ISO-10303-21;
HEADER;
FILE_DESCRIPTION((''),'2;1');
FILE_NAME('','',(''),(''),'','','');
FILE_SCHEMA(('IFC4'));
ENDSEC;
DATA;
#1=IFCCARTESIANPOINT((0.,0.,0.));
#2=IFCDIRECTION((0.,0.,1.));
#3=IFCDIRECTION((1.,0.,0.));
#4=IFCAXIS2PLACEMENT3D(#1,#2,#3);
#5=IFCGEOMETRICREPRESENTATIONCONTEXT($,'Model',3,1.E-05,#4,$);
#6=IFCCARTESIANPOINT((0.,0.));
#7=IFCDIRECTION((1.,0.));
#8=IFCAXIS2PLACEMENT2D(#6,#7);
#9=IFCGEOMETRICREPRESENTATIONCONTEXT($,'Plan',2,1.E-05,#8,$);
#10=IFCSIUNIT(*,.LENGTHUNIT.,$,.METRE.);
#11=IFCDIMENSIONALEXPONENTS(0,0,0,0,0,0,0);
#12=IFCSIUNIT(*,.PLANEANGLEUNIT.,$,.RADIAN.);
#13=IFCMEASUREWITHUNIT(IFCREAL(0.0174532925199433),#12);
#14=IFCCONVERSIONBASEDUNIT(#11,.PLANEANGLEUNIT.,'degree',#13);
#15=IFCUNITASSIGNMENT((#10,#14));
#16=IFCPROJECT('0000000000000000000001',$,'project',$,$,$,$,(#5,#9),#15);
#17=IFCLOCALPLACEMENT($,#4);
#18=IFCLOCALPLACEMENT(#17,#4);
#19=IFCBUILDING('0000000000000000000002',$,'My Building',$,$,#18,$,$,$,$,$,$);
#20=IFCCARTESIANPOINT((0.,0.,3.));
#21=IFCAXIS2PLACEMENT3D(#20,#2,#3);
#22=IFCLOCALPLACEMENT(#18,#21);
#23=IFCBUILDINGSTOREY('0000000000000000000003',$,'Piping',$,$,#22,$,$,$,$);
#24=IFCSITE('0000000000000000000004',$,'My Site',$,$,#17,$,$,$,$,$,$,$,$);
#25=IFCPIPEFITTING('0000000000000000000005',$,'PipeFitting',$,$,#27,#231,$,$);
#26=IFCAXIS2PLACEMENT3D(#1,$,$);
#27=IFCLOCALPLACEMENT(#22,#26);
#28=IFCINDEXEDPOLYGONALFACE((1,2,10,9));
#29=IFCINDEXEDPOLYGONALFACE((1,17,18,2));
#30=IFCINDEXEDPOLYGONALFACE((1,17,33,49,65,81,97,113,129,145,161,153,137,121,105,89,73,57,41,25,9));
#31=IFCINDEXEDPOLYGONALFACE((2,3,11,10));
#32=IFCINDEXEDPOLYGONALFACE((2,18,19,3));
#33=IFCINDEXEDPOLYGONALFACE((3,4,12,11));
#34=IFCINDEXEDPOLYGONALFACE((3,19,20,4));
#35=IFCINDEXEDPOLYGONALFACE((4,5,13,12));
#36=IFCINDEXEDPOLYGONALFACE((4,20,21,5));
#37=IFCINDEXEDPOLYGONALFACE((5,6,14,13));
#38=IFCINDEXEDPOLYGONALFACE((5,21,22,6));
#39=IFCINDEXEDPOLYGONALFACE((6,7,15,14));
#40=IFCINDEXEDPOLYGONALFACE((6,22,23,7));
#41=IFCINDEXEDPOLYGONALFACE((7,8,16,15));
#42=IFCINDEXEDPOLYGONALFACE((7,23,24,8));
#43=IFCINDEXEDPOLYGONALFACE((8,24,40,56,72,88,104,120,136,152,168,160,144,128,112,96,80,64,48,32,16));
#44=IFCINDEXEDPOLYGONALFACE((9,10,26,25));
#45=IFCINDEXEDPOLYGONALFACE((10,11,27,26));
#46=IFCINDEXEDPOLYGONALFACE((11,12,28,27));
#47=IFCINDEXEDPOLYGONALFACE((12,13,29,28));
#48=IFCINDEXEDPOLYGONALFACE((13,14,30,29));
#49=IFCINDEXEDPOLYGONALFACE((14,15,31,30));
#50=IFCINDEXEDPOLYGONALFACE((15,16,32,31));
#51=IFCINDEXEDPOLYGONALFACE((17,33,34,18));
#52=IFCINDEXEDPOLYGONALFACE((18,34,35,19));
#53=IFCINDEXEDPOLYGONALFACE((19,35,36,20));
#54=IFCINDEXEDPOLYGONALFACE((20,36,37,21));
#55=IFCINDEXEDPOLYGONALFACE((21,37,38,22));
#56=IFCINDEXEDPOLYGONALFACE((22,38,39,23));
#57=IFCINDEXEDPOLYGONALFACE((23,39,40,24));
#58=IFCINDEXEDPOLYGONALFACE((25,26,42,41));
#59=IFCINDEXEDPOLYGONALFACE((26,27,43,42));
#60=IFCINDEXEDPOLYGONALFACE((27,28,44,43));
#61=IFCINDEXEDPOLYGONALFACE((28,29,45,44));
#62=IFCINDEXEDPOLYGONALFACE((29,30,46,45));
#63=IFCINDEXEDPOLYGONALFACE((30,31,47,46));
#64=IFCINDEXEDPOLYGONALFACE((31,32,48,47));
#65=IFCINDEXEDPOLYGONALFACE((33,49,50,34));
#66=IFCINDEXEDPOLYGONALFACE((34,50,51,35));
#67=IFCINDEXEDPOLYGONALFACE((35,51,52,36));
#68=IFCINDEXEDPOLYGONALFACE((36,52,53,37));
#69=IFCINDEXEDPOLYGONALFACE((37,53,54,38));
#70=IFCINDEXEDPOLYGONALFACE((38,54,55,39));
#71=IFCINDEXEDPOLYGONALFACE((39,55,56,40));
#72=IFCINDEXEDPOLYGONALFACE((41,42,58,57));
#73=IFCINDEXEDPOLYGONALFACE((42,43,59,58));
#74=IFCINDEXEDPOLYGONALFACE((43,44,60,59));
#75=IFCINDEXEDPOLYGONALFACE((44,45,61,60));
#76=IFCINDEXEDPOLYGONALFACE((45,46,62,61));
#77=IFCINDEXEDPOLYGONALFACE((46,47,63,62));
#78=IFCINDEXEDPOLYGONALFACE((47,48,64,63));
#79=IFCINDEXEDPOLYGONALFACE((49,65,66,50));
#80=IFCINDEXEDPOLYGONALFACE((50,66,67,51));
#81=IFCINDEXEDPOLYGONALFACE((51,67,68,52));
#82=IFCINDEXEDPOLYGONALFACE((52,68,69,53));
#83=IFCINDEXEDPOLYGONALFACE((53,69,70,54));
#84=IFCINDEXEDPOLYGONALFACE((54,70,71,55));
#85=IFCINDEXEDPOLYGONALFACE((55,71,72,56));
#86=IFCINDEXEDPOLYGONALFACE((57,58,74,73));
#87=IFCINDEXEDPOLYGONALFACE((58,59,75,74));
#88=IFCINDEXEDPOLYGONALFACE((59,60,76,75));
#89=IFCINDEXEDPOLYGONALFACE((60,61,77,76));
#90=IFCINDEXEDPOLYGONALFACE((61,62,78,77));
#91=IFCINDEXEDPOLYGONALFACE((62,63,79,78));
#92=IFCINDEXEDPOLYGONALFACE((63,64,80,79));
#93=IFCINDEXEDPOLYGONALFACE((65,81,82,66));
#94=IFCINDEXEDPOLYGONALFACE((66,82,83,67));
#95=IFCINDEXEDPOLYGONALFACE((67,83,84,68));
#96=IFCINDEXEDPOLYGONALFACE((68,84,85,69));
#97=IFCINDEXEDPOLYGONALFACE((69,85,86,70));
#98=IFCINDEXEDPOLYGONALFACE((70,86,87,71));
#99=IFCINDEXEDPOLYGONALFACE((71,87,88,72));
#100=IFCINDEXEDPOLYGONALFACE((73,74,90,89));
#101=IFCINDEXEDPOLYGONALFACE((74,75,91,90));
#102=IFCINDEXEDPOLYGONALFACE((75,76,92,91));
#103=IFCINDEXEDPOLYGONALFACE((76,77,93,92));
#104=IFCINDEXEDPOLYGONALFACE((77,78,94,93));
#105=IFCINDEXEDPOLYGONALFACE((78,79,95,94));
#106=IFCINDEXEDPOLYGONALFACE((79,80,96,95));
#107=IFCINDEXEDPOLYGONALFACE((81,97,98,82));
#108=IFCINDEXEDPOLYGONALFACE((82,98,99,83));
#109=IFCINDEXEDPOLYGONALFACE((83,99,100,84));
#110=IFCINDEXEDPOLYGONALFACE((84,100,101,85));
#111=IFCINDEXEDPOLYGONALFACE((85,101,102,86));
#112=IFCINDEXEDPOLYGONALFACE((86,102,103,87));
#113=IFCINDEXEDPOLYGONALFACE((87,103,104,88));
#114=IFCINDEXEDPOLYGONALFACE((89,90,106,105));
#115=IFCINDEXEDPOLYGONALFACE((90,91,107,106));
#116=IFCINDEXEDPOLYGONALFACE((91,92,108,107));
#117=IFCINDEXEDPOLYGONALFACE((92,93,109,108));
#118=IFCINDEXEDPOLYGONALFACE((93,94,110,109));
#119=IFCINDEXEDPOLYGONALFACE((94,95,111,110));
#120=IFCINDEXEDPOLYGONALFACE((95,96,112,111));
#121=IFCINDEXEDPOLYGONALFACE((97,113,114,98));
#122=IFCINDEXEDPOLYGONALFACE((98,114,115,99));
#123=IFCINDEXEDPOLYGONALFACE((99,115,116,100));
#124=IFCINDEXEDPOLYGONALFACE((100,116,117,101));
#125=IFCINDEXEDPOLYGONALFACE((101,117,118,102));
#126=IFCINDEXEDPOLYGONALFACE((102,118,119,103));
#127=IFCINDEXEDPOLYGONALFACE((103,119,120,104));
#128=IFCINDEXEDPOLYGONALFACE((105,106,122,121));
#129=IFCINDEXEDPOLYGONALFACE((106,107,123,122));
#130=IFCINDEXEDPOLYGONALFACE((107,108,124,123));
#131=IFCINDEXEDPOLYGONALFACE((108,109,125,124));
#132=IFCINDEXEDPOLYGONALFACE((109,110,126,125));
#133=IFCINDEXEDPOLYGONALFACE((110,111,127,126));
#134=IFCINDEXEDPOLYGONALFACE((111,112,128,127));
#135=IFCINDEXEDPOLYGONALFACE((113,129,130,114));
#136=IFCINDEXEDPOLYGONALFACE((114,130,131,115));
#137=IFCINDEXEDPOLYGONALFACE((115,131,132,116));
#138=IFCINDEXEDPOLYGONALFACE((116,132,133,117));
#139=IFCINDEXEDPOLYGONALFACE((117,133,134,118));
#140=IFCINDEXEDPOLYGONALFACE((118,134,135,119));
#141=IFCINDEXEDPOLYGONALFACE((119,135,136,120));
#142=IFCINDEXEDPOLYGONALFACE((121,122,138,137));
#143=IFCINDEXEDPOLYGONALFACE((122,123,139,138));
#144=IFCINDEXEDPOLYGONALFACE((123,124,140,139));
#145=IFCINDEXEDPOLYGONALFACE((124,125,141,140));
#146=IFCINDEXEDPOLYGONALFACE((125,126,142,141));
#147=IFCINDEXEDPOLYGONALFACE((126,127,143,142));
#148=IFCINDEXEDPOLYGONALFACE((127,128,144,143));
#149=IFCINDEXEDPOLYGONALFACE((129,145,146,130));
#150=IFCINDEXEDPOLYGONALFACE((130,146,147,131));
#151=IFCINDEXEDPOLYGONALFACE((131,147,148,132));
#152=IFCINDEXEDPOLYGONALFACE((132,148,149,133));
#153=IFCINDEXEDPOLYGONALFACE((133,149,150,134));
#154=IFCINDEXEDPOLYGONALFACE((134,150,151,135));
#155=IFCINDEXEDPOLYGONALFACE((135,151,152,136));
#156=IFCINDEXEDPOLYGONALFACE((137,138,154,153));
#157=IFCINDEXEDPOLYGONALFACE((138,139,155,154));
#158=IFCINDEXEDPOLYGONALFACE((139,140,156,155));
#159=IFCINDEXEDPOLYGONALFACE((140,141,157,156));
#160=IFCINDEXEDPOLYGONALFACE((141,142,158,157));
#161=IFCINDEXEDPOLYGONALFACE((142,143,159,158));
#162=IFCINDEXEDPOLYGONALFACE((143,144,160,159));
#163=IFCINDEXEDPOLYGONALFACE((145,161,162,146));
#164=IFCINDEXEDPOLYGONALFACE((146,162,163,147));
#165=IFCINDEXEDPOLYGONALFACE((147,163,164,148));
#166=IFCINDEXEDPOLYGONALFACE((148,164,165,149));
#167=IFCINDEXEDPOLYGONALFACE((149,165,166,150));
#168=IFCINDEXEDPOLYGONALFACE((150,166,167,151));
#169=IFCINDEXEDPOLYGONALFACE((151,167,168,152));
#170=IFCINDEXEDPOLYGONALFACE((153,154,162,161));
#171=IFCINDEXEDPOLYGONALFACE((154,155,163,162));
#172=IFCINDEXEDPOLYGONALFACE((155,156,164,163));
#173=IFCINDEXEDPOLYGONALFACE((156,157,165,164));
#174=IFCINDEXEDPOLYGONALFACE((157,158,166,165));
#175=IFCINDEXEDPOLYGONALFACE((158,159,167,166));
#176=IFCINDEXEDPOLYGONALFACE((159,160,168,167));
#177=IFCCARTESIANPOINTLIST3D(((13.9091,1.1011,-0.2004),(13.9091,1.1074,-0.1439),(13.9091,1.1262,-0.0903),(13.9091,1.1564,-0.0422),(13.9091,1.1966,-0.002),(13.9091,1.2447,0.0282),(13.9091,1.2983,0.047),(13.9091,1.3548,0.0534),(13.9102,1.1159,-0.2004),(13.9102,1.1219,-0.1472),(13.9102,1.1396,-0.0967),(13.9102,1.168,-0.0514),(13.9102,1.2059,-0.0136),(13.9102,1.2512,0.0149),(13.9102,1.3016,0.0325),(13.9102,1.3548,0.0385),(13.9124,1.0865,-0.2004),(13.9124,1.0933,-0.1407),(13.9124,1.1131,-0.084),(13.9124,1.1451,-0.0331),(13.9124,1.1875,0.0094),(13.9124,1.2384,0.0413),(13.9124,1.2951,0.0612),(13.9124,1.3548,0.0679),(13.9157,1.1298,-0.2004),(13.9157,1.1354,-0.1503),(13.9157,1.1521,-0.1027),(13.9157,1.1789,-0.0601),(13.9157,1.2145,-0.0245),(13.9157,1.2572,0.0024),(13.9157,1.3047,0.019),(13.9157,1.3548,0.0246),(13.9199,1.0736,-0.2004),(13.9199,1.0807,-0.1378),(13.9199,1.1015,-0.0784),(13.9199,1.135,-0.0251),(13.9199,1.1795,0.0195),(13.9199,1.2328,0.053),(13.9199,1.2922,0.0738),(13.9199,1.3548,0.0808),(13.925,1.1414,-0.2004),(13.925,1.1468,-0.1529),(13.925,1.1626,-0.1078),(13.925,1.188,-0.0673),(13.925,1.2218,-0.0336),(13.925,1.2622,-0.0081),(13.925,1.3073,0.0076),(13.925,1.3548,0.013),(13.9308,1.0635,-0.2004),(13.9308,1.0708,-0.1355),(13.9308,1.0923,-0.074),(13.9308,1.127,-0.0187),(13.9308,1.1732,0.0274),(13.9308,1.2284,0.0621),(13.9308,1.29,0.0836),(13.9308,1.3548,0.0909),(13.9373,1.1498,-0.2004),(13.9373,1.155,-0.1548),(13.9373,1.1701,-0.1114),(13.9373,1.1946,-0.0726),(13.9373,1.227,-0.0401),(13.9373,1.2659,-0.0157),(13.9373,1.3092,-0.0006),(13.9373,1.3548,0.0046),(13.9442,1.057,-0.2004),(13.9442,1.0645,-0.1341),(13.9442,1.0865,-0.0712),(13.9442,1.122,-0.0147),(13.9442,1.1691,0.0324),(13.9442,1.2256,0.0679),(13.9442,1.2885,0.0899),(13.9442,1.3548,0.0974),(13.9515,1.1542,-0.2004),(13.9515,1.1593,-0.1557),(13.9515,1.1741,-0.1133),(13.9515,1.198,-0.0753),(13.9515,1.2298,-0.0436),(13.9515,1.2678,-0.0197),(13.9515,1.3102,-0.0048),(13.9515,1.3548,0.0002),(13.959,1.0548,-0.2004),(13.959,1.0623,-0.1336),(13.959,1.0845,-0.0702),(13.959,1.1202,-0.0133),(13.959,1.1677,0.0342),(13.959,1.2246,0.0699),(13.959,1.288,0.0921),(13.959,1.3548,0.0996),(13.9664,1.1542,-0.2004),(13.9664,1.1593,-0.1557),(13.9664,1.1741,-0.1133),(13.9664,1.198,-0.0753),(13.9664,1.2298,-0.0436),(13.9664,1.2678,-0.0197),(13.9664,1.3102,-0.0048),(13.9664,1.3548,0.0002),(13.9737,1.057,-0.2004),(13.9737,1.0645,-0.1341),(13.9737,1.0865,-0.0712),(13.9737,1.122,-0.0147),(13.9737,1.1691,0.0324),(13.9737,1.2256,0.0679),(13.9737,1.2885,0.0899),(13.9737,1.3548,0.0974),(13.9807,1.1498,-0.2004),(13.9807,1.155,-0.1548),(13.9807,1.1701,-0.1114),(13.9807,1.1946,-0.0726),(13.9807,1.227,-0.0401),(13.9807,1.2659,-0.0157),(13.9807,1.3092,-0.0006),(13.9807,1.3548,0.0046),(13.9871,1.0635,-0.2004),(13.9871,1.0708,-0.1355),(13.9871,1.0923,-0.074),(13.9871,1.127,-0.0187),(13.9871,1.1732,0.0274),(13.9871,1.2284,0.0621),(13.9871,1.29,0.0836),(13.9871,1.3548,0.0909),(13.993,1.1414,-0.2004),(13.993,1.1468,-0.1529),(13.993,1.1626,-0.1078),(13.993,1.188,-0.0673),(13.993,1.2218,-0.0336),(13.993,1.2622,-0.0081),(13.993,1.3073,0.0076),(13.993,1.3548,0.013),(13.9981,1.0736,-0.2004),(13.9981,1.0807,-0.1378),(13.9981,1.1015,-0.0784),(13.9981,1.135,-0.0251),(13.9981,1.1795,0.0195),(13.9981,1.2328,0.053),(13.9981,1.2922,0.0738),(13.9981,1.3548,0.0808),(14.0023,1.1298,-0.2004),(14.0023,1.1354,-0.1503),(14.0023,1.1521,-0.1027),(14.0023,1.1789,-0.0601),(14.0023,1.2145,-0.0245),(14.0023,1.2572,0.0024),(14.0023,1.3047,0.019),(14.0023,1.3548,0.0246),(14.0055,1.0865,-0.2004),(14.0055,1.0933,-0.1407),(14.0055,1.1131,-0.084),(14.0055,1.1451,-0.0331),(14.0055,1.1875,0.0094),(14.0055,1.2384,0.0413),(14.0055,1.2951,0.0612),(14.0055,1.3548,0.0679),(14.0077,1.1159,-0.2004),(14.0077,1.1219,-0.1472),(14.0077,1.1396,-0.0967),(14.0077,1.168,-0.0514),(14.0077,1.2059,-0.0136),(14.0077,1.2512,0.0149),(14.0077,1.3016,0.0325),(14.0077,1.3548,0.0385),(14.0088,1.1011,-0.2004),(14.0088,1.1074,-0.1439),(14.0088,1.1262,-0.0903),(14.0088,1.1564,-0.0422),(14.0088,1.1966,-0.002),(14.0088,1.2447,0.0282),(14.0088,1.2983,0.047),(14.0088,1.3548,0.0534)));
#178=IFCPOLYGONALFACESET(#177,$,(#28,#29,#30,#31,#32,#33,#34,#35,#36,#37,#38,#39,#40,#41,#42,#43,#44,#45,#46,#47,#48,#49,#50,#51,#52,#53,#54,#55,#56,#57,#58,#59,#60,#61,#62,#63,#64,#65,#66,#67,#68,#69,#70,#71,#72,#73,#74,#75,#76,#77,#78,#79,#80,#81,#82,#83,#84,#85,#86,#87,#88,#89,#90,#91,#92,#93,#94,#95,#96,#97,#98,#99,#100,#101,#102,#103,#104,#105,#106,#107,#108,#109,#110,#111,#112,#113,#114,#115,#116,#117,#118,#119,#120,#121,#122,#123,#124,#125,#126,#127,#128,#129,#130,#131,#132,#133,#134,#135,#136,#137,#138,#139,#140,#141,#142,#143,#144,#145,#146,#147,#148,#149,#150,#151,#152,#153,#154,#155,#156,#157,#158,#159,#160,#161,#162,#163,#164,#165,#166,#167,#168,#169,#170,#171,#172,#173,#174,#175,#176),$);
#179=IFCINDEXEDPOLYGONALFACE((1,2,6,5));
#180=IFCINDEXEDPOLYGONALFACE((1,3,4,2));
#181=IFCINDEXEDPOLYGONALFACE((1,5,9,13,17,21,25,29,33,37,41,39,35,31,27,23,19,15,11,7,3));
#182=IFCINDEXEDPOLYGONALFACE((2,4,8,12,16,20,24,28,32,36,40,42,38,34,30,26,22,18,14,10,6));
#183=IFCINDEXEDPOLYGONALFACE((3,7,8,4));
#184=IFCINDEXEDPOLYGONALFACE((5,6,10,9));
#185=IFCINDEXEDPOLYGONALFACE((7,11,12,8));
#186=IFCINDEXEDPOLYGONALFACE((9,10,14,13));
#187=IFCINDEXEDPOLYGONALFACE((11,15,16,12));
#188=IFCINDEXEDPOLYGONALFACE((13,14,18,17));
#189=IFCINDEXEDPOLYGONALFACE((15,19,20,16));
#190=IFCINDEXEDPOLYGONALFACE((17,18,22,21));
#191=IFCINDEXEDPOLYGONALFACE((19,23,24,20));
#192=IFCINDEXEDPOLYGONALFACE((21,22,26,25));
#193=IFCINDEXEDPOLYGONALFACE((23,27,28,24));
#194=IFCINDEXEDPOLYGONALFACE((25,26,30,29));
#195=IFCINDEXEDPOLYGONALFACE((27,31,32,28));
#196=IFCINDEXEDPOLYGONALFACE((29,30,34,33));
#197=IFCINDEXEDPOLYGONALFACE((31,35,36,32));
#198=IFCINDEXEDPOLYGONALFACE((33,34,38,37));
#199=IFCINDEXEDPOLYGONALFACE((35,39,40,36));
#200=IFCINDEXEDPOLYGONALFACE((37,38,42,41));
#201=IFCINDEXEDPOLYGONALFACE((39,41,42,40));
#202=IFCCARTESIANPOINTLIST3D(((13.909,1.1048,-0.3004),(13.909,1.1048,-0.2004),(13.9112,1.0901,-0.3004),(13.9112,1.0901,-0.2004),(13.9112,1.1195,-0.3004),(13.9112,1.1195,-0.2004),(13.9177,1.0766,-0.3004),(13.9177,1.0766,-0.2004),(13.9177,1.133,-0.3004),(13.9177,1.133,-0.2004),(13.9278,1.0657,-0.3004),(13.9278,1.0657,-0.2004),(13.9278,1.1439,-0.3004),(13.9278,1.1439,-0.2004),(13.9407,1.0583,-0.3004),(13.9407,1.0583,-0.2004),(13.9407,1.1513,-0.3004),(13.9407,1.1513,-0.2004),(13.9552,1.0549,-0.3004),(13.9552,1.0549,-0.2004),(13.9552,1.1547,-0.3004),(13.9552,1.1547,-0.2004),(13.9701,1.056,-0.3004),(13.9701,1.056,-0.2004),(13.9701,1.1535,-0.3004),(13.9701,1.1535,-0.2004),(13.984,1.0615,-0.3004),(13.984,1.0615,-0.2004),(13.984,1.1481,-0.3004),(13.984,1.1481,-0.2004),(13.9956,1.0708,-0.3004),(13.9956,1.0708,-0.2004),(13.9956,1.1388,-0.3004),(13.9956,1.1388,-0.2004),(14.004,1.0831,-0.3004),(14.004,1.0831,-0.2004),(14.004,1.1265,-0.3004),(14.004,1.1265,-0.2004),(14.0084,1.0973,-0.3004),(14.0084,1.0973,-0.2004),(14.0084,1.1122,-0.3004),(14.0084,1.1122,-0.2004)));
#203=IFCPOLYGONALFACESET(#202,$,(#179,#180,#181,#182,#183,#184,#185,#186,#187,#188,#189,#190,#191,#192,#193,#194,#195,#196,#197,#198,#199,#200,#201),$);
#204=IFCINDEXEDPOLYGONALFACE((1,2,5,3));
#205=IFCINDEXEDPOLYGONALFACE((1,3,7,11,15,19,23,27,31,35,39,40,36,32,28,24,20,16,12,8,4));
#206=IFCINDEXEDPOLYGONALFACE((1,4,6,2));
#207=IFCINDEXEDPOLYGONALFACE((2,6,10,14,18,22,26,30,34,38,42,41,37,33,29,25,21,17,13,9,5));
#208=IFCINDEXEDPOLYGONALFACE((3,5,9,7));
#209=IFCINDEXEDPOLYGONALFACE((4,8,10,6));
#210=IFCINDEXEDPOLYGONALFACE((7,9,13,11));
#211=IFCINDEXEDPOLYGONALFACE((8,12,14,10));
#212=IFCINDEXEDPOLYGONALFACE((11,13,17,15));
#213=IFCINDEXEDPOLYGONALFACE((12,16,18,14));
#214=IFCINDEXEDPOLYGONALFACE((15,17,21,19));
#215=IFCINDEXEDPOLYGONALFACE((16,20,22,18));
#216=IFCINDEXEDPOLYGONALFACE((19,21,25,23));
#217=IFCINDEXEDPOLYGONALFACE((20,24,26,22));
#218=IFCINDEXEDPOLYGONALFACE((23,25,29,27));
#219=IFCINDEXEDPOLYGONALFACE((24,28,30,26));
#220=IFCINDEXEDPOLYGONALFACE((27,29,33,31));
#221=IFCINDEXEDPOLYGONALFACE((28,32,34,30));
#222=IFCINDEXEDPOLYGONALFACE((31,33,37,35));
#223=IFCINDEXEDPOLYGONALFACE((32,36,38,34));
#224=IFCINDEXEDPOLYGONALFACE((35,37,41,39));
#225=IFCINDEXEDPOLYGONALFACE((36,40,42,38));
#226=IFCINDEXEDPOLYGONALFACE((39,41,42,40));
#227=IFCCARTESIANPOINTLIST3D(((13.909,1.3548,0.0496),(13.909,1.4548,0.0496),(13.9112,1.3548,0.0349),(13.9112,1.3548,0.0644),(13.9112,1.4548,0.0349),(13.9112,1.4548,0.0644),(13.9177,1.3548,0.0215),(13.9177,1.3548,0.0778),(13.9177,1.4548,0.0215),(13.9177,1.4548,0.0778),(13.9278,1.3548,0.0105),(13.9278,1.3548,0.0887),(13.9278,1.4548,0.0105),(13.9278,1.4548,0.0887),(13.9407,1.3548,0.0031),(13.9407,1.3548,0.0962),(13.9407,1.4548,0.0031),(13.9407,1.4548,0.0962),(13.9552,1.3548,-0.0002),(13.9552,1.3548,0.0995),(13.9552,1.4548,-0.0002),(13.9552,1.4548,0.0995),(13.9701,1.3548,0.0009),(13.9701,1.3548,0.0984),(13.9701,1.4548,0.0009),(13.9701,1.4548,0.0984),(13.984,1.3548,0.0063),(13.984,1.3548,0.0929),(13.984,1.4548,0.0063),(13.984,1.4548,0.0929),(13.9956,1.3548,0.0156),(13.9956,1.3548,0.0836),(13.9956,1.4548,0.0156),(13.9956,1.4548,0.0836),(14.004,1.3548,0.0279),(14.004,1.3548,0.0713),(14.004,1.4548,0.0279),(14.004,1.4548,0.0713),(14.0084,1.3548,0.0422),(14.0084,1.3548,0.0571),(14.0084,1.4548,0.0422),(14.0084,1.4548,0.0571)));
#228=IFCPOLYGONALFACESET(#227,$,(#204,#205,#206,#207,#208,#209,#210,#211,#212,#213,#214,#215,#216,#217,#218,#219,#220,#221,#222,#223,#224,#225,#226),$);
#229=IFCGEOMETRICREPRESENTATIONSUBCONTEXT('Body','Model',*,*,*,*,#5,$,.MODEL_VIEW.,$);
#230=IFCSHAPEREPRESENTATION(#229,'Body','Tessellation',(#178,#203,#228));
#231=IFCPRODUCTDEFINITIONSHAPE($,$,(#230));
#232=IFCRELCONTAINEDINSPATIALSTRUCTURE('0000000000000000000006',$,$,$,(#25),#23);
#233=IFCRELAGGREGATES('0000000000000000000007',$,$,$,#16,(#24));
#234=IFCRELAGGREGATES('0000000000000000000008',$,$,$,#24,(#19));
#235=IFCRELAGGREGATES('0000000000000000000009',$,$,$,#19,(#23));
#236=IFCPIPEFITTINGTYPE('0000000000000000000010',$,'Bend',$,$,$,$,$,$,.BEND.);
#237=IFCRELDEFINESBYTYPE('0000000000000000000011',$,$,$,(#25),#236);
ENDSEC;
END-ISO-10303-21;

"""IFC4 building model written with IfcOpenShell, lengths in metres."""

from ifc_helpers import new_model, entity, si_unit, converted_unit, frame, origin_with_axes, origin_2d_with_axis, place, context, subcontext, project, spatial, circle, extrude, source, transform, mapped, type_object, type_shapes, element, save


model = new_model("IFC4")

# Units and contexts
model_context = context("Model", 3, precision=1e-05, world=origin_with_axes())
plan_context = context("Plan", 2, precision=1e-05, world=origin_2d_with_axis())
body_context = subcontext(model_context, "Body", "Model", "MODEL_VIEW")
ifc_project = project(units=[si_unit("LENGTHUNIT", "METRE"), converted_unit("PLANEANGLEUNIT", "degree", entity("IfcReal", 0.0174532925199433), si_unit("PLANEANGLEUNIT", "RADIAN"), dimensions=[0, 0, 0, 0, 0, 0, 0])], contexts=[model_context, plan_context])

# Site, building, storey
site_placement = place(None, origin_with_axes())
site = spatial("IfcSite", under=ifc_project, at=site_placement, Name="My Site")
building_placement = place(site_placement, origin_with_axes())
building = spatial("IfcBuilding", under=site, at=building_placement, Name="My Building")
storey_placement = place(building_placement, frame((0.0, 0.0, 3.0), z_axis=(0.0, 0.0, 1.0), x_axis=(1.0, 0.0, 0.0)))
storey = spatial("IfcBuildingStorey", under=building, at=storey_placement, Name="Piping")

# Pipe fitting
pipe_fitting_type = type_object("IfcPipeFittingType", Name="Bend", PredefinedType="BEND")
shared_shape = source(origin_with_axes(), body_context, "Body", "SolidModel", [
    entity("IfcSweptDiskSolid", entity("IfcIndexedPolyCurve", entity("IfcCartesianPointList3D", [[0.0, 0.0, -0.1], [0.0, 0.0732, -0.2768], [0.0, 0.25, -0.35]]), [entity("IfcArcIndex", [1, 2, 3])]), 0.05),
    extrude(circle(Radius=0.05), origin_with_axes(), (0.0, 0.0, -1.0), 0.1),
    extrude(circle(Radius=0.05), frame((0.0, 0.25, -0.35), z_axis=(0.0, 1.0, 0.000007), x_axis=(1.0, 0.0, 0.0)), (0.0, 0.0, 1.0), 0.1),
])
type_shapes(pipe_fitting_type, [shared_shape])
for number, where, z_axis, x_axis, name in (
    (1, (13.959, 1.1048, -0.3004), (0.0, 0.0, -1.0), (-1.0, 0.0, 0.0), "PipeFitting"),
):
    element("IfcPipeFitting", number, at=place(storey_placement, frame(where, z_axis=z_axis, x_axis=x_axis)), inside=storey, type_object=pipe_fitting_type, Name=name, context=body_context, shape_type="MappedRepresentation", body=[
        mapped(shared_shape, transform((0.0, 0.0, 0.0), x_axis=(1.0, 0.0, 0.0), y_axis=(0.0, 1.0, 0.0), z_axis=(0.0, 0.0, 1.0), scale=1.0)),
    ])

save(model, "model.ifc")
